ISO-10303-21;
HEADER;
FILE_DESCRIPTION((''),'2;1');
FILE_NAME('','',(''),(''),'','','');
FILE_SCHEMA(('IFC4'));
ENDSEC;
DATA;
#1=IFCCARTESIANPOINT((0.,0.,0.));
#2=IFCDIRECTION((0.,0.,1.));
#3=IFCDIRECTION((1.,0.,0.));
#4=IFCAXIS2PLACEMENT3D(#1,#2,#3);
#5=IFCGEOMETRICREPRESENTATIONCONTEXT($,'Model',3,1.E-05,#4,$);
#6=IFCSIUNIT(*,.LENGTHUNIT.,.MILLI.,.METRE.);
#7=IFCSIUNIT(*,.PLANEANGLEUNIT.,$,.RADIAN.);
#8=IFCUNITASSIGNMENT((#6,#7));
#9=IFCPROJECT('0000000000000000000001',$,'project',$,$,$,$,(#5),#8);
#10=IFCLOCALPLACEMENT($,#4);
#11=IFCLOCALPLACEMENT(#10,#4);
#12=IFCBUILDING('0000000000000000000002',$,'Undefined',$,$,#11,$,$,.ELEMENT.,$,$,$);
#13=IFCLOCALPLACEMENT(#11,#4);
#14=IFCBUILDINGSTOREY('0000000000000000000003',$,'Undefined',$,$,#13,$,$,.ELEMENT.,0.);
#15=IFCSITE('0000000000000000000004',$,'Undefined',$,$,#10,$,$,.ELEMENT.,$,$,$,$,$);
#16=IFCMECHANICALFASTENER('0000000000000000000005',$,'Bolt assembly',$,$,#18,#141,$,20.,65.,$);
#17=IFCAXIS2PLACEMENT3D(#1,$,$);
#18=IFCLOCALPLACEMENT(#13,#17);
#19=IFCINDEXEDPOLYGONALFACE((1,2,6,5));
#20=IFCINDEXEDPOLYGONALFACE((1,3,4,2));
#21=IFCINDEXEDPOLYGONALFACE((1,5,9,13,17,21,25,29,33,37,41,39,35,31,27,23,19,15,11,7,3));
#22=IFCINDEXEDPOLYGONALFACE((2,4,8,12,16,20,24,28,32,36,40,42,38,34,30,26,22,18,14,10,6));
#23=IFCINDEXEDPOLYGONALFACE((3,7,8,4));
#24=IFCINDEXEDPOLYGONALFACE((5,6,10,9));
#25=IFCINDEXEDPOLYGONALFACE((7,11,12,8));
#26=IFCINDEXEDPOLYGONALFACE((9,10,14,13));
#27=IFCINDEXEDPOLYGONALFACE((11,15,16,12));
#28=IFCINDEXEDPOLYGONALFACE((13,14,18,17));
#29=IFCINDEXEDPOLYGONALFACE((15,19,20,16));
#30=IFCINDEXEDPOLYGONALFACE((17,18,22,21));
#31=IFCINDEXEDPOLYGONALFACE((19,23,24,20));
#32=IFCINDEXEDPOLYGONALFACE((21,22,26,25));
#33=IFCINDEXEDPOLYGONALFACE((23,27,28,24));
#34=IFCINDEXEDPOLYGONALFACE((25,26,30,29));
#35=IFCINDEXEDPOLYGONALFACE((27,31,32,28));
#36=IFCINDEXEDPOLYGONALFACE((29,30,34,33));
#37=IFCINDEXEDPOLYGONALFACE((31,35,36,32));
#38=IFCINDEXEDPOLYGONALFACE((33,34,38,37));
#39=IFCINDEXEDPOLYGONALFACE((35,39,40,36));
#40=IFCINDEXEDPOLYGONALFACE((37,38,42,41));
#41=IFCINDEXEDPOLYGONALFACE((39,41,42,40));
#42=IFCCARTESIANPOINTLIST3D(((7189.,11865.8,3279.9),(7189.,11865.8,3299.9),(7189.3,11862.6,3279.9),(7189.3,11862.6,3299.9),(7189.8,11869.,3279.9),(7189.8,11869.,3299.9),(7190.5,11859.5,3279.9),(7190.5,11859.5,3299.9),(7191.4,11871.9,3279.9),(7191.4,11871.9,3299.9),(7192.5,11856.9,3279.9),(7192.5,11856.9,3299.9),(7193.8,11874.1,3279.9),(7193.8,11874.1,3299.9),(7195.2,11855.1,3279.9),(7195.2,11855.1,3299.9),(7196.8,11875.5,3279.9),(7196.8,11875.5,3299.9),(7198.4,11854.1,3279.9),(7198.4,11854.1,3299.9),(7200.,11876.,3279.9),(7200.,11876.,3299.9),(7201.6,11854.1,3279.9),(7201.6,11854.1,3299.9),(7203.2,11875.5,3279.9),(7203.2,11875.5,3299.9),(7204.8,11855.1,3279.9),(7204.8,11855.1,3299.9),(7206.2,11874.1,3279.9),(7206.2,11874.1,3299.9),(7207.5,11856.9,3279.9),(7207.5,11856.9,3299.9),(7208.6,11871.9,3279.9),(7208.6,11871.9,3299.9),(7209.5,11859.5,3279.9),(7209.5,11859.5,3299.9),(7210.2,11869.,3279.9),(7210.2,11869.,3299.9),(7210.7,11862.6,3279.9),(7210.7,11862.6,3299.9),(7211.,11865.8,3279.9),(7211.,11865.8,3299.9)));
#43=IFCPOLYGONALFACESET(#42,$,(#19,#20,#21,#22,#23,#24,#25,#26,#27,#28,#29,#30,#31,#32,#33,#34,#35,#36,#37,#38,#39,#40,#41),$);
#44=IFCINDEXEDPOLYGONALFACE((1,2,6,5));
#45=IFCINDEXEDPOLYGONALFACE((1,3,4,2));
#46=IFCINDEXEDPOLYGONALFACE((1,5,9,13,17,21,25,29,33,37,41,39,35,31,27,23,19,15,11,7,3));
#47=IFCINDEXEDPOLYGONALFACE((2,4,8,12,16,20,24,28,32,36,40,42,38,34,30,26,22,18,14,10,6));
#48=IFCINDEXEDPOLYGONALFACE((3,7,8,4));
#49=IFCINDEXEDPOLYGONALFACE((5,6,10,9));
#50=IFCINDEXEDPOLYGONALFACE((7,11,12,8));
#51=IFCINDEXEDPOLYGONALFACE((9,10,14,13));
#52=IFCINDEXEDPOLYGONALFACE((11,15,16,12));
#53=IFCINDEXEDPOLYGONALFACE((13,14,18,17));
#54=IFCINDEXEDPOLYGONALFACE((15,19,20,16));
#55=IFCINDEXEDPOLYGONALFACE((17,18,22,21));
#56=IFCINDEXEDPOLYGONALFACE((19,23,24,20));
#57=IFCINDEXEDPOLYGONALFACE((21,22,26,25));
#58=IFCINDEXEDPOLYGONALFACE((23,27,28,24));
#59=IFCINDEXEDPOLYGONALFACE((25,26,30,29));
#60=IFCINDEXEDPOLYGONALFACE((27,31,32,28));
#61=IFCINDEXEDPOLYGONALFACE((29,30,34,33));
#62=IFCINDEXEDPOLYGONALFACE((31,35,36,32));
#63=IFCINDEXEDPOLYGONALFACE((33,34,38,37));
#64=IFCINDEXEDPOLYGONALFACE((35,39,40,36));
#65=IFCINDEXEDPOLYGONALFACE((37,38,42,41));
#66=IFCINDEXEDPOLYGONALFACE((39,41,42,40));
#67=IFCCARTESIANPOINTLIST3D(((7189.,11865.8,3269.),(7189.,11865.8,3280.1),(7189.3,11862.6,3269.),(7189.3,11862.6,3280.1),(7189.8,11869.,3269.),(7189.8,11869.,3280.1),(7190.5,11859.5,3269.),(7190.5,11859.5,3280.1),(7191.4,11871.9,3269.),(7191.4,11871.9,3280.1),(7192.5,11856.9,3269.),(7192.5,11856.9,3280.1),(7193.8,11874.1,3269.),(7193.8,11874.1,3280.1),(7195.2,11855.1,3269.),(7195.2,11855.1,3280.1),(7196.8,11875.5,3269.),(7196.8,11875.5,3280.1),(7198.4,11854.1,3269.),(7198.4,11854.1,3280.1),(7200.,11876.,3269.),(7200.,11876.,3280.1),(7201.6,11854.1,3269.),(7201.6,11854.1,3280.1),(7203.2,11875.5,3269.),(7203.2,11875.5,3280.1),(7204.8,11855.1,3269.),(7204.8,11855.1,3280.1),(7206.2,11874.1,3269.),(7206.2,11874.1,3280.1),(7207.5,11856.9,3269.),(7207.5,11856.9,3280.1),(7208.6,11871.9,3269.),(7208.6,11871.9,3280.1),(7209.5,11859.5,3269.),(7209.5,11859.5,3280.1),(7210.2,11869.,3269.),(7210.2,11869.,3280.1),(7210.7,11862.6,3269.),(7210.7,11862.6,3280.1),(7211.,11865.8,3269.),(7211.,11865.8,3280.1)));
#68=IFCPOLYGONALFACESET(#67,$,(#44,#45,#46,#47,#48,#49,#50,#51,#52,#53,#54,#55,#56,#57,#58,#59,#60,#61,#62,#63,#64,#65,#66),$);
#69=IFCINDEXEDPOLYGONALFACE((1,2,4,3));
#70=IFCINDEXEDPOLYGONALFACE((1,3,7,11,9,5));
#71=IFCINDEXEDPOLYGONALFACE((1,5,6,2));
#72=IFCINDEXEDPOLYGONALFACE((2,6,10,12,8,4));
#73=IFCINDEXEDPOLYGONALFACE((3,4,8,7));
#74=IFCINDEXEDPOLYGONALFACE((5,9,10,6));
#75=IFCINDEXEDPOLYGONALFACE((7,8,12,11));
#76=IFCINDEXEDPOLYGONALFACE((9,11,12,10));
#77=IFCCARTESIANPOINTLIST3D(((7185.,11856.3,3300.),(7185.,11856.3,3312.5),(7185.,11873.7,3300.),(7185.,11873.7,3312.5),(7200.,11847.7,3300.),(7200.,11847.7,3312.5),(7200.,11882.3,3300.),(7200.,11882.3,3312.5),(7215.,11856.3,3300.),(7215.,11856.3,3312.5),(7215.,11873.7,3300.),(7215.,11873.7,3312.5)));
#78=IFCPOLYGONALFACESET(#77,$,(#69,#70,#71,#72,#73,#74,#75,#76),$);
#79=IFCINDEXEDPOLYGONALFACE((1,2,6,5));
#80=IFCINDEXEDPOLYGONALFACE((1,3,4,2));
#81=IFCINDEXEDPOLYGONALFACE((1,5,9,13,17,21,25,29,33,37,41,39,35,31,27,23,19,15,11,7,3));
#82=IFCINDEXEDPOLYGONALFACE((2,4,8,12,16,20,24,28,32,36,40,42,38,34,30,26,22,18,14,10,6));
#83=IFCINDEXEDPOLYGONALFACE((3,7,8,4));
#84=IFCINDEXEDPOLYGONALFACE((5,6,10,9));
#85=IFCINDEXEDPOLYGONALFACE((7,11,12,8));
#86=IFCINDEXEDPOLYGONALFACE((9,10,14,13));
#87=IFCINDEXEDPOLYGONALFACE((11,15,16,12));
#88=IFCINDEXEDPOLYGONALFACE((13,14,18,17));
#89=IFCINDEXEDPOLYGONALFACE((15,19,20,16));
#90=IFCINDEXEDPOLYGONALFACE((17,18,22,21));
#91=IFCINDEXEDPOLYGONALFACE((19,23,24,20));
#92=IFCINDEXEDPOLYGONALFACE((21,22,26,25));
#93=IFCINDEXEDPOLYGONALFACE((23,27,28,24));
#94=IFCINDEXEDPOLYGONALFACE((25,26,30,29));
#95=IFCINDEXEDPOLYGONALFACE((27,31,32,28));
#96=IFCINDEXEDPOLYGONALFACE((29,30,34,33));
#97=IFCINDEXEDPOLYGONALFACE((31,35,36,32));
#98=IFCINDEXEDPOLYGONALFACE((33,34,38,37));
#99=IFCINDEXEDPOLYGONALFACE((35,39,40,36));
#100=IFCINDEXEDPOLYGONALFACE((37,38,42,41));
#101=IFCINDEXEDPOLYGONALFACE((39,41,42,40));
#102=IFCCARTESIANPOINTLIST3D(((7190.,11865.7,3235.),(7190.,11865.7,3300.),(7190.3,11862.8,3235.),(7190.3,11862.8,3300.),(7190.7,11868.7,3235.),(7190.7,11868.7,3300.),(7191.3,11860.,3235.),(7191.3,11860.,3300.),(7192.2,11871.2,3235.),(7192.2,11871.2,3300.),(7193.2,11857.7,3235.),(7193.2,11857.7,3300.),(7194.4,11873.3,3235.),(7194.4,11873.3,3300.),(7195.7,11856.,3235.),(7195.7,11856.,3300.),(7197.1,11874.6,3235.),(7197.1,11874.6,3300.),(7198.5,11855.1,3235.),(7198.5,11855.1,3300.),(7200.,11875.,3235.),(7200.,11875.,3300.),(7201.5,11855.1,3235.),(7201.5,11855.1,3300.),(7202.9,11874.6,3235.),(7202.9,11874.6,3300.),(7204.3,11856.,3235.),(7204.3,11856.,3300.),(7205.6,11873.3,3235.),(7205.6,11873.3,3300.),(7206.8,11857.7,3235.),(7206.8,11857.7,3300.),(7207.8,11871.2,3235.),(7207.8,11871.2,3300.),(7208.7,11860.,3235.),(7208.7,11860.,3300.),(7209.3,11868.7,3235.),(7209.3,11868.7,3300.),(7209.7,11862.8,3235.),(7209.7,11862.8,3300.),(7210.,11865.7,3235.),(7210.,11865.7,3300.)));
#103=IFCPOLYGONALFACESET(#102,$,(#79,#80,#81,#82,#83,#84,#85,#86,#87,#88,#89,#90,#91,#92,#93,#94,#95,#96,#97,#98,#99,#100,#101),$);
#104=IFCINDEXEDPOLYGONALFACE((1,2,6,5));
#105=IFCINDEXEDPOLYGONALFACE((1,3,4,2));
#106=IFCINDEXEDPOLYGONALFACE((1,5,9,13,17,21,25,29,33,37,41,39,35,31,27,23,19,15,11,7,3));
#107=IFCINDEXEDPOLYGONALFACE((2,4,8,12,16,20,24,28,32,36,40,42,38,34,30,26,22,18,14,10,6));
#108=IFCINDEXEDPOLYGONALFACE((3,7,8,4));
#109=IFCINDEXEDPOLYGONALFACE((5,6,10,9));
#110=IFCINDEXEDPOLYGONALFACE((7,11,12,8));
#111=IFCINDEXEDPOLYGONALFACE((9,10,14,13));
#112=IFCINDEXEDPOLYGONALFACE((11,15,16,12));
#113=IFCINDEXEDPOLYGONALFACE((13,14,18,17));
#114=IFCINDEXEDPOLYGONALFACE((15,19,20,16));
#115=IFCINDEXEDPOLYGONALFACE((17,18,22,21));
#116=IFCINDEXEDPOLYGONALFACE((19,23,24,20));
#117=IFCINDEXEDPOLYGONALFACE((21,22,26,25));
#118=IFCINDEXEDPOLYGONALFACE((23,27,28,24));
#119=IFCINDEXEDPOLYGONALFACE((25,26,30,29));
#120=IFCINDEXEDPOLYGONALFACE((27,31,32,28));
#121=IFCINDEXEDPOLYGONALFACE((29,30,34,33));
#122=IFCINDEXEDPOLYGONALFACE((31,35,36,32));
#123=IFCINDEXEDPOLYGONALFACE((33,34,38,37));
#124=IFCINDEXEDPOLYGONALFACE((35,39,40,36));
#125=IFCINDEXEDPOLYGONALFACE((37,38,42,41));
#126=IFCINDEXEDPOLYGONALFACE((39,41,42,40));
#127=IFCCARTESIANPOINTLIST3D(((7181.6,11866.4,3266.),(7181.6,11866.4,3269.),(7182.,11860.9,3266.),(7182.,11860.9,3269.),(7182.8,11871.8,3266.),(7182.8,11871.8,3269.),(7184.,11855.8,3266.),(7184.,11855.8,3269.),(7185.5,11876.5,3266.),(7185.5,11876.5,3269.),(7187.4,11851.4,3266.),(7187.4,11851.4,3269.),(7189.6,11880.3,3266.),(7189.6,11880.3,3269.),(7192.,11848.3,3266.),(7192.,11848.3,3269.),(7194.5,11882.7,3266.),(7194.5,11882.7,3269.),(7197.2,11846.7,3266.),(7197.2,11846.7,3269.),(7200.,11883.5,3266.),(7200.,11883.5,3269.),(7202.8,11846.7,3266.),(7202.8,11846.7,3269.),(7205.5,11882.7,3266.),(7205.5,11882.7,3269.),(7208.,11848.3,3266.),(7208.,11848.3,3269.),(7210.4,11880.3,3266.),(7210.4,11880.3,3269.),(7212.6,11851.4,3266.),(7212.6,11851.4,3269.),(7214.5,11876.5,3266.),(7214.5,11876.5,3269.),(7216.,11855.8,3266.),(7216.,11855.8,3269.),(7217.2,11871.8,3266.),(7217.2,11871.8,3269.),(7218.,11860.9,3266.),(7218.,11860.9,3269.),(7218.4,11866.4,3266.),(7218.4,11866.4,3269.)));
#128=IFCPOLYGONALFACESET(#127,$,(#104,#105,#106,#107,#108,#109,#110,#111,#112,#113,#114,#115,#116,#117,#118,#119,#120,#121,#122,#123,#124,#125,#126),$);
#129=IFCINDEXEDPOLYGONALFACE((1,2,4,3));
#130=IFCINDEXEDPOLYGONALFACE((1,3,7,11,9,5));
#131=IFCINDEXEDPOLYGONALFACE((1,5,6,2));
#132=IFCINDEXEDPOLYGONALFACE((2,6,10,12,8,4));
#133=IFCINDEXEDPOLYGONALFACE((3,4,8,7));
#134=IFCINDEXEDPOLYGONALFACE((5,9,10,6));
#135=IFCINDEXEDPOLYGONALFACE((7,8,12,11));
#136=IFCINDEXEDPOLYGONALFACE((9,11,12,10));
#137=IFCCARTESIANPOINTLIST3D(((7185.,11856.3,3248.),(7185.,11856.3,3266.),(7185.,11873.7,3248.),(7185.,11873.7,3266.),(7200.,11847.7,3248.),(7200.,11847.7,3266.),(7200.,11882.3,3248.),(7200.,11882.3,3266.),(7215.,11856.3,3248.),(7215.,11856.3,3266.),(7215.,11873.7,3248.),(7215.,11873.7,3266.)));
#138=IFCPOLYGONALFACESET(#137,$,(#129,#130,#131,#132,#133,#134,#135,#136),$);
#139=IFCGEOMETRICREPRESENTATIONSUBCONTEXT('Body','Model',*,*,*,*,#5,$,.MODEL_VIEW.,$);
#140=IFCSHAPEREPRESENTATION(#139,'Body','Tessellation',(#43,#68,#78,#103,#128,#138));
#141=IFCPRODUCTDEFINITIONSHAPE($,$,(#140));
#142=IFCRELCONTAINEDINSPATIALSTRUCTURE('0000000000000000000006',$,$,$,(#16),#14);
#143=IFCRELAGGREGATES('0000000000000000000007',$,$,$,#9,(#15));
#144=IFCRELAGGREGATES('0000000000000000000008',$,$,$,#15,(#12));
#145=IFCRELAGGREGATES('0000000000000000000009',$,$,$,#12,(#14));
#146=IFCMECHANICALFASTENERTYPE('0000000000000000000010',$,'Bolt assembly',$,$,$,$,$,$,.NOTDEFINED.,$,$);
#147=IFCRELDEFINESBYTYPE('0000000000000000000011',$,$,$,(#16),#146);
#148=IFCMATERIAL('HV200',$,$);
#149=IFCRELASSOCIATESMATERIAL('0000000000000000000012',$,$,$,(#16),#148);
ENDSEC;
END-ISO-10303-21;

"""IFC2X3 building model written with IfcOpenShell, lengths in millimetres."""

from ifc_helpers import new_model, si_unit, frame, origin_with_axes, origin_2d_with_axis, place, context, subcontext, project, spatial, polyline, circle, outline, extrude, source, transform, mapped, material, type_object, element, save


model = new_model("IFC2X3")

# Units and contexts
model_context = context("Model", 3, precision=1e-05, world=origin_with_axes())
body_context = subcontext(model_context, "Body", "Model", "MODEL_VIEW")
ifc_project = project(units=[si_unit("LENGTHUNIT", "METRE", prefix="MILLI"), si_unit("PLANEANGLEUNIT", "RADIAN")], contexts=[model_context])

# Site, building, storey
site_placement = place(None, origin_with_axes())
site = spatial("IfcSite", under=ifc_project, at=site_placement, Name="Undefined", CompositionType="ELEMENT")
building_placement = place(site_placement, origin_with_axes())
building = spatial("IfcBuilding", under=site, at=building_placement, Name="Undefined", CompositionType="ELEMENT")
storey_placement = place(building_placement, origin_with_axes())
storey = spatial("IfcBuildingStorey", under=building, at=storey_placement, Name="Undefined", CompositionType="ELEMENT", Elevation=0.0)

# Mechanical fastener
ifc_material_1 = material(Name="HV200")
mechanical_fastener_type = type_object("IfcMechanicalFastenerType", Name="Bolt assembly")
shared_shape_1 = source(origin_with_axes(), body_context, "Body", "SweptSolid", [
    extrude(circle(Radius=11.0, at=origin_2d_with_axis()), frame((0.0, -19.9, 0.0), z_axis=(0.0, 1.0, 0.0), x_axis=(1.0, 0.0, 0.0)), (0.0, 0.0, 1.0), 20.0),
    extrude(circle(Radius=11.0, at=origin_2d_with_axis()), frame((0.0, -0.1, 0.0), z_axis=(0.0, 1.0, 0.0), x_axis=(1.0, 0.0, 0.0)), (0.0, 0.0, 1.0), 11.1),
    extrude(outline(polyline([(17.3, 0.0), (8.7, 15.0), (-8.7, 15.0), (-17.3, 0.0), (-8.7, -15.0), (8.7, -15.0), (17.3, 0.0)])), frame((0.0, -32.5, 0.0), z_axis=(0.0, 1.0, 0.0), x_axis=(1.0, 0.0, 0.0)), (0.0, 0.0, 1.0), 12.5),
    extrude(circle(Radius=10.0, at=origin_2d_with_axis()), frame((0.0, -20.0, 0.0), z_axis=(0.0, 1.0, 0.0), x_axis=(1.0, 0.0, 0.0)), (0.0, 0.0, 1.0), 65.0),
    extrude(circle(Radius=18.5, at=origin_2d_with_axis()), frame((0.0, 11.0, 0.0), z_axis=(0.0, 1.0, 0.0), x_axis=(1.0, 0.0, 0.0)), (0.0, 0.0, 1.0), 3.0),
    extrude(outline(polyline([(17.3, 0.0), (8.7, 15.0), (-8.7, 15.0), (-17.3, 0.0), (-8.7, -15.0), (8.7, -15.0), (17.3, 0.0)])), frame((0.0, 14.0, 0.0), z_axis=(0.0, 1.0, 0.0), x_axis=(1.0, 0.0, 0.0)), (0.0, 0.0, 1.0), 18.0),
])
for number, where, z_axis, x_axis, name in (
    (1, (7200.0, 11865.0, 3280.0), (-1.0, 0.0, 0.0), (0.0, 1.0, 0.0), "Bolt assembly"),
):
    element("IfcMechanicalFastener", number, at=place(storey_placement, frame(where, z_axis=z_axis, x_axis=x_axis)), inside=storey, type_object=mechanical_fastener_type, material=ifc_material_1, Name=name, NominalDiameter=20.0, NominalLength=65.0, context=body_context, shape_type="MappedRepresentation", body=[
        mapped(shared_shape_1, transform((0.0, 0.0, 0.0))),
    ])

save(model, "model.ifc")
